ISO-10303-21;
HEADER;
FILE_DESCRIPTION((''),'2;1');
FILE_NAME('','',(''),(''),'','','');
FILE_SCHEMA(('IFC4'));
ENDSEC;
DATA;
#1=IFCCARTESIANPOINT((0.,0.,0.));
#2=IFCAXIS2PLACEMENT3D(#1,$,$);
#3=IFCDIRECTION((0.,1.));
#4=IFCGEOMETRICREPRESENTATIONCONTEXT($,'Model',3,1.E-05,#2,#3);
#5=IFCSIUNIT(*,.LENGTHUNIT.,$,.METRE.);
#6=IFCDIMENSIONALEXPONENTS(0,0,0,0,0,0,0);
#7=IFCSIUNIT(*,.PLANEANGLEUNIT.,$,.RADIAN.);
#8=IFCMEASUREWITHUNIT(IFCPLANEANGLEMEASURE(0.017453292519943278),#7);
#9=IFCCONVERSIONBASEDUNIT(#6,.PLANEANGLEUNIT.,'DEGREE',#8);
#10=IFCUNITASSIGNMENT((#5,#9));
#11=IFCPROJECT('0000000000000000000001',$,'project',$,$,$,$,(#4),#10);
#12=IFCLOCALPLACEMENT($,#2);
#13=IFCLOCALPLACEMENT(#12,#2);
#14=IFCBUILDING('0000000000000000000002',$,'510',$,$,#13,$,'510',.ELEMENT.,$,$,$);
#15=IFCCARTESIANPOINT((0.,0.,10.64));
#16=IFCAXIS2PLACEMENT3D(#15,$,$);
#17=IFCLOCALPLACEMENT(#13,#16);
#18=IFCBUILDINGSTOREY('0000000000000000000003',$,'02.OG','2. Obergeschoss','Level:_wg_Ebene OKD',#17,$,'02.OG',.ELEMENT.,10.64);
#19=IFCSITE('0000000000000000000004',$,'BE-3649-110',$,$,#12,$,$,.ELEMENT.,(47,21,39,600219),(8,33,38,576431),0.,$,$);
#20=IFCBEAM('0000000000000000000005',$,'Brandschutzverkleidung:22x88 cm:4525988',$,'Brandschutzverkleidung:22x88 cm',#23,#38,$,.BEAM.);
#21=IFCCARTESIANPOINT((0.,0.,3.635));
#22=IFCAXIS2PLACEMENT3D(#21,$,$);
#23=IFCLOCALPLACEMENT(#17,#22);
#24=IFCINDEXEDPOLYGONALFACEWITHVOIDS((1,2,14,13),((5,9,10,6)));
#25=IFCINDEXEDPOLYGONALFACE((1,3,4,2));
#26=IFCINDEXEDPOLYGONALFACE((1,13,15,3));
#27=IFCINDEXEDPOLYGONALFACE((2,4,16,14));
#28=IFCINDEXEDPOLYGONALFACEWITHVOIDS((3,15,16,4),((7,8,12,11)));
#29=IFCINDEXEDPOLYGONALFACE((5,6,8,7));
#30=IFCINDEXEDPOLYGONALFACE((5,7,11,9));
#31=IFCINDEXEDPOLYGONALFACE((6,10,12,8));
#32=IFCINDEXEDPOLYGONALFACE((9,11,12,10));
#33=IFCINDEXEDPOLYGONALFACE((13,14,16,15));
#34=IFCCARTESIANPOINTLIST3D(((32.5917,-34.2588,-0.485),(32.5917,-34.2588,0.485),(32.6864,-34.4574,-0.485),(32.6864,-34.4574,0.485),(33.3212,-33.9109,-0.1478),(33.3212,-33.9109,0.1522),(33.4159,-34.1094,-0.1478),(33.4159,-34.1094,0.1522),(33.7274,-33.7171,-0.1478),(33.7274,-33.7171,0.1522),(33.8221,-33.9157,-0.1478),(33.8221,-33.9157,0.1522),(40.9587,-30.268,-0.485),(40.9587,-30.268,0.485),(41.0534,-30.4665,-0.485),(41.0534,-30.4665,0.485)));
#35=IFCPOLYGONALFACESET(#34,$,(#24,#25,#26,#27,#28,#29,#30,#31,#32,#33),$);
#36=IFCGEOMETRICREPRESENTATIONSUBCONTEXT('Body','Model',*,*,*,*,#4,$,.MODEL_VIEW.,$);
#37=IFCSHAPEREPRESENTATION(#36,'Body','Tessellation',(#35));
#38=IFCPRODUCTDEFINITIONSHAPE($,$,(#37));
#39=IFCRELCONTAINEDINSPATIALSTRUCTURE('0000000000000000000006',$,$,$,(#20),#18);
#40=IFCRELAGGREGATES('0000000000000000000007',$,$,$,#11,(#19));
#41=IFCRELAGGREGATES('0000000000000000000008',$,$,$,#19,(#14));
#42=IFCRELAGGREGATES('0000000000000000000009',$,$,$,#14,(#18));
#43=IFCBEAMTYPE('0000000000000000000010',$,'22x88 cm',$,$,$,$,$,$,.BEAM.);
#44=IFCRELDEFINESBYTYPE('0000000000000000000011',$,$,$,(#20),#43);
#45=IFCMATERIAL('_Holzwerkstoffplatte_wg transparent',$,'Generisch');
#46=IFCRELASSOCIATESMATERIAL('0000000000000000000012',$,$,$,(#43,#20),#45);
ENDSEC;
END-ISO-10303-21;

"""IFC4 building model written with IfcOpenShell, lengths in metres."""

from ifc_helpers import new_model, entity, si_unit, converted_unit, direction, frame, origin, place, context, subcontext, project, spatial, indexed_curve, outline, extrude, source, transform, mapped, material, type_object, type_shapes, element, save


model = new_model("IFC4")

# Units and contexts
model_context = context("Model", 3, precision=1e-05, world=origin(), true_north=direction((0.0, 1.0)))
body_context = subcontext(model_context, "Body", "Model", "MODEL_VIEW")
ifc_project = project(units=[si_unit("LENGTHUNIT", "METRE"), converted_unit("PLANEANGLEUNIT", "DEGREE", entity("IfcPlaneAngleMeasure", 0.017453292519943278), si_unit("PLANEANGLEUNIT", "RADIAN"), dimensions=[0, 0, 0, 0, 0, 0, 0])], contexts=[model_context])

# Site, building, storey
site_placement = place(None, origin())
site = spatial("IfcSite", under=ifc_project, at=site_placement, Name="BE-3649-110", CompositionType="ELEMENT", RefLatitude=(47, 21, 39, 600219), RefLongitude=(8, 33, 38, 576431), RefElevation=0.0)
building_placement = place(site_placement, origin())
building = spatial("IfcBuilding", under=site, at=building_placement, Name="510", LongName="510", CompositionType="ELEMENT")
storey_placement = place(building_placement, frame((0.0, 0.0, 10.64)))
storey = spatial("IfcBuildingStorey", under=building, at=storey_placement, Name="02.OG", Description="2. Obergeschoss", ObjectType="Level:_wg_Ebene OKD", LongName="02.OG", CompositionType="ELEMENT", Elevation=10.64)

# Shared definitions
ifc_material_1 = material(Name="_Holzwerkstoffplatte_wg transparent", Category="Generisch")

# Beam
beam_type_1 = type_object("IfcBeamType", Name="22x88 cm", PredefinedType="BEAM", material=ifc_material_1)
shared_shape_1 = source(origin(), body_context, "Body", "SweptSolid", [
    extrude(outline(indexed_curve([(-4.635, -0.485), (4.635, -0.485), (4.635, 0.485), (-4.635, 0.485), (-4.635, -0.485)], self_intersect=False), holes=[indexed_curve([(3.3767, -0.1478), (3.3767, 0.1522), (3.8267, 0.1522), (3.8267, -0.1478), (3.3767, -0.1478)], self_intersect=False)]), frame((36.8699, -32.462, 0.0), z_axis=(-0.430511, 0.902585, 0.0), x_axis=(-0.902585, -0.430511, 0.0)), (0.0, 0.0, 1.0), 0.22),
])
type_shapes(beam_type_1, [shared_shape_1])
beam_1_placement = place(storey_placement, frame((0.0, 0.0, 3.635)))
element("IfcBeam", 1, at=beam_1_placement, inside=storey, type_object=beam_type_1, material=ifc_material_1, Name="Brandschutzverkleidung:22x88 cm:4525988", ObjectType="Brandschutzverkleidung:22x88 cm", PredefinedType="BEAM", context=body_context, shape_type="MappedRepresentation", body=[
    mapped(shared_shape_1, transform((0.0, 0.0, 0.0), scale=1.0)),
])

save(model, "model.ifc")
